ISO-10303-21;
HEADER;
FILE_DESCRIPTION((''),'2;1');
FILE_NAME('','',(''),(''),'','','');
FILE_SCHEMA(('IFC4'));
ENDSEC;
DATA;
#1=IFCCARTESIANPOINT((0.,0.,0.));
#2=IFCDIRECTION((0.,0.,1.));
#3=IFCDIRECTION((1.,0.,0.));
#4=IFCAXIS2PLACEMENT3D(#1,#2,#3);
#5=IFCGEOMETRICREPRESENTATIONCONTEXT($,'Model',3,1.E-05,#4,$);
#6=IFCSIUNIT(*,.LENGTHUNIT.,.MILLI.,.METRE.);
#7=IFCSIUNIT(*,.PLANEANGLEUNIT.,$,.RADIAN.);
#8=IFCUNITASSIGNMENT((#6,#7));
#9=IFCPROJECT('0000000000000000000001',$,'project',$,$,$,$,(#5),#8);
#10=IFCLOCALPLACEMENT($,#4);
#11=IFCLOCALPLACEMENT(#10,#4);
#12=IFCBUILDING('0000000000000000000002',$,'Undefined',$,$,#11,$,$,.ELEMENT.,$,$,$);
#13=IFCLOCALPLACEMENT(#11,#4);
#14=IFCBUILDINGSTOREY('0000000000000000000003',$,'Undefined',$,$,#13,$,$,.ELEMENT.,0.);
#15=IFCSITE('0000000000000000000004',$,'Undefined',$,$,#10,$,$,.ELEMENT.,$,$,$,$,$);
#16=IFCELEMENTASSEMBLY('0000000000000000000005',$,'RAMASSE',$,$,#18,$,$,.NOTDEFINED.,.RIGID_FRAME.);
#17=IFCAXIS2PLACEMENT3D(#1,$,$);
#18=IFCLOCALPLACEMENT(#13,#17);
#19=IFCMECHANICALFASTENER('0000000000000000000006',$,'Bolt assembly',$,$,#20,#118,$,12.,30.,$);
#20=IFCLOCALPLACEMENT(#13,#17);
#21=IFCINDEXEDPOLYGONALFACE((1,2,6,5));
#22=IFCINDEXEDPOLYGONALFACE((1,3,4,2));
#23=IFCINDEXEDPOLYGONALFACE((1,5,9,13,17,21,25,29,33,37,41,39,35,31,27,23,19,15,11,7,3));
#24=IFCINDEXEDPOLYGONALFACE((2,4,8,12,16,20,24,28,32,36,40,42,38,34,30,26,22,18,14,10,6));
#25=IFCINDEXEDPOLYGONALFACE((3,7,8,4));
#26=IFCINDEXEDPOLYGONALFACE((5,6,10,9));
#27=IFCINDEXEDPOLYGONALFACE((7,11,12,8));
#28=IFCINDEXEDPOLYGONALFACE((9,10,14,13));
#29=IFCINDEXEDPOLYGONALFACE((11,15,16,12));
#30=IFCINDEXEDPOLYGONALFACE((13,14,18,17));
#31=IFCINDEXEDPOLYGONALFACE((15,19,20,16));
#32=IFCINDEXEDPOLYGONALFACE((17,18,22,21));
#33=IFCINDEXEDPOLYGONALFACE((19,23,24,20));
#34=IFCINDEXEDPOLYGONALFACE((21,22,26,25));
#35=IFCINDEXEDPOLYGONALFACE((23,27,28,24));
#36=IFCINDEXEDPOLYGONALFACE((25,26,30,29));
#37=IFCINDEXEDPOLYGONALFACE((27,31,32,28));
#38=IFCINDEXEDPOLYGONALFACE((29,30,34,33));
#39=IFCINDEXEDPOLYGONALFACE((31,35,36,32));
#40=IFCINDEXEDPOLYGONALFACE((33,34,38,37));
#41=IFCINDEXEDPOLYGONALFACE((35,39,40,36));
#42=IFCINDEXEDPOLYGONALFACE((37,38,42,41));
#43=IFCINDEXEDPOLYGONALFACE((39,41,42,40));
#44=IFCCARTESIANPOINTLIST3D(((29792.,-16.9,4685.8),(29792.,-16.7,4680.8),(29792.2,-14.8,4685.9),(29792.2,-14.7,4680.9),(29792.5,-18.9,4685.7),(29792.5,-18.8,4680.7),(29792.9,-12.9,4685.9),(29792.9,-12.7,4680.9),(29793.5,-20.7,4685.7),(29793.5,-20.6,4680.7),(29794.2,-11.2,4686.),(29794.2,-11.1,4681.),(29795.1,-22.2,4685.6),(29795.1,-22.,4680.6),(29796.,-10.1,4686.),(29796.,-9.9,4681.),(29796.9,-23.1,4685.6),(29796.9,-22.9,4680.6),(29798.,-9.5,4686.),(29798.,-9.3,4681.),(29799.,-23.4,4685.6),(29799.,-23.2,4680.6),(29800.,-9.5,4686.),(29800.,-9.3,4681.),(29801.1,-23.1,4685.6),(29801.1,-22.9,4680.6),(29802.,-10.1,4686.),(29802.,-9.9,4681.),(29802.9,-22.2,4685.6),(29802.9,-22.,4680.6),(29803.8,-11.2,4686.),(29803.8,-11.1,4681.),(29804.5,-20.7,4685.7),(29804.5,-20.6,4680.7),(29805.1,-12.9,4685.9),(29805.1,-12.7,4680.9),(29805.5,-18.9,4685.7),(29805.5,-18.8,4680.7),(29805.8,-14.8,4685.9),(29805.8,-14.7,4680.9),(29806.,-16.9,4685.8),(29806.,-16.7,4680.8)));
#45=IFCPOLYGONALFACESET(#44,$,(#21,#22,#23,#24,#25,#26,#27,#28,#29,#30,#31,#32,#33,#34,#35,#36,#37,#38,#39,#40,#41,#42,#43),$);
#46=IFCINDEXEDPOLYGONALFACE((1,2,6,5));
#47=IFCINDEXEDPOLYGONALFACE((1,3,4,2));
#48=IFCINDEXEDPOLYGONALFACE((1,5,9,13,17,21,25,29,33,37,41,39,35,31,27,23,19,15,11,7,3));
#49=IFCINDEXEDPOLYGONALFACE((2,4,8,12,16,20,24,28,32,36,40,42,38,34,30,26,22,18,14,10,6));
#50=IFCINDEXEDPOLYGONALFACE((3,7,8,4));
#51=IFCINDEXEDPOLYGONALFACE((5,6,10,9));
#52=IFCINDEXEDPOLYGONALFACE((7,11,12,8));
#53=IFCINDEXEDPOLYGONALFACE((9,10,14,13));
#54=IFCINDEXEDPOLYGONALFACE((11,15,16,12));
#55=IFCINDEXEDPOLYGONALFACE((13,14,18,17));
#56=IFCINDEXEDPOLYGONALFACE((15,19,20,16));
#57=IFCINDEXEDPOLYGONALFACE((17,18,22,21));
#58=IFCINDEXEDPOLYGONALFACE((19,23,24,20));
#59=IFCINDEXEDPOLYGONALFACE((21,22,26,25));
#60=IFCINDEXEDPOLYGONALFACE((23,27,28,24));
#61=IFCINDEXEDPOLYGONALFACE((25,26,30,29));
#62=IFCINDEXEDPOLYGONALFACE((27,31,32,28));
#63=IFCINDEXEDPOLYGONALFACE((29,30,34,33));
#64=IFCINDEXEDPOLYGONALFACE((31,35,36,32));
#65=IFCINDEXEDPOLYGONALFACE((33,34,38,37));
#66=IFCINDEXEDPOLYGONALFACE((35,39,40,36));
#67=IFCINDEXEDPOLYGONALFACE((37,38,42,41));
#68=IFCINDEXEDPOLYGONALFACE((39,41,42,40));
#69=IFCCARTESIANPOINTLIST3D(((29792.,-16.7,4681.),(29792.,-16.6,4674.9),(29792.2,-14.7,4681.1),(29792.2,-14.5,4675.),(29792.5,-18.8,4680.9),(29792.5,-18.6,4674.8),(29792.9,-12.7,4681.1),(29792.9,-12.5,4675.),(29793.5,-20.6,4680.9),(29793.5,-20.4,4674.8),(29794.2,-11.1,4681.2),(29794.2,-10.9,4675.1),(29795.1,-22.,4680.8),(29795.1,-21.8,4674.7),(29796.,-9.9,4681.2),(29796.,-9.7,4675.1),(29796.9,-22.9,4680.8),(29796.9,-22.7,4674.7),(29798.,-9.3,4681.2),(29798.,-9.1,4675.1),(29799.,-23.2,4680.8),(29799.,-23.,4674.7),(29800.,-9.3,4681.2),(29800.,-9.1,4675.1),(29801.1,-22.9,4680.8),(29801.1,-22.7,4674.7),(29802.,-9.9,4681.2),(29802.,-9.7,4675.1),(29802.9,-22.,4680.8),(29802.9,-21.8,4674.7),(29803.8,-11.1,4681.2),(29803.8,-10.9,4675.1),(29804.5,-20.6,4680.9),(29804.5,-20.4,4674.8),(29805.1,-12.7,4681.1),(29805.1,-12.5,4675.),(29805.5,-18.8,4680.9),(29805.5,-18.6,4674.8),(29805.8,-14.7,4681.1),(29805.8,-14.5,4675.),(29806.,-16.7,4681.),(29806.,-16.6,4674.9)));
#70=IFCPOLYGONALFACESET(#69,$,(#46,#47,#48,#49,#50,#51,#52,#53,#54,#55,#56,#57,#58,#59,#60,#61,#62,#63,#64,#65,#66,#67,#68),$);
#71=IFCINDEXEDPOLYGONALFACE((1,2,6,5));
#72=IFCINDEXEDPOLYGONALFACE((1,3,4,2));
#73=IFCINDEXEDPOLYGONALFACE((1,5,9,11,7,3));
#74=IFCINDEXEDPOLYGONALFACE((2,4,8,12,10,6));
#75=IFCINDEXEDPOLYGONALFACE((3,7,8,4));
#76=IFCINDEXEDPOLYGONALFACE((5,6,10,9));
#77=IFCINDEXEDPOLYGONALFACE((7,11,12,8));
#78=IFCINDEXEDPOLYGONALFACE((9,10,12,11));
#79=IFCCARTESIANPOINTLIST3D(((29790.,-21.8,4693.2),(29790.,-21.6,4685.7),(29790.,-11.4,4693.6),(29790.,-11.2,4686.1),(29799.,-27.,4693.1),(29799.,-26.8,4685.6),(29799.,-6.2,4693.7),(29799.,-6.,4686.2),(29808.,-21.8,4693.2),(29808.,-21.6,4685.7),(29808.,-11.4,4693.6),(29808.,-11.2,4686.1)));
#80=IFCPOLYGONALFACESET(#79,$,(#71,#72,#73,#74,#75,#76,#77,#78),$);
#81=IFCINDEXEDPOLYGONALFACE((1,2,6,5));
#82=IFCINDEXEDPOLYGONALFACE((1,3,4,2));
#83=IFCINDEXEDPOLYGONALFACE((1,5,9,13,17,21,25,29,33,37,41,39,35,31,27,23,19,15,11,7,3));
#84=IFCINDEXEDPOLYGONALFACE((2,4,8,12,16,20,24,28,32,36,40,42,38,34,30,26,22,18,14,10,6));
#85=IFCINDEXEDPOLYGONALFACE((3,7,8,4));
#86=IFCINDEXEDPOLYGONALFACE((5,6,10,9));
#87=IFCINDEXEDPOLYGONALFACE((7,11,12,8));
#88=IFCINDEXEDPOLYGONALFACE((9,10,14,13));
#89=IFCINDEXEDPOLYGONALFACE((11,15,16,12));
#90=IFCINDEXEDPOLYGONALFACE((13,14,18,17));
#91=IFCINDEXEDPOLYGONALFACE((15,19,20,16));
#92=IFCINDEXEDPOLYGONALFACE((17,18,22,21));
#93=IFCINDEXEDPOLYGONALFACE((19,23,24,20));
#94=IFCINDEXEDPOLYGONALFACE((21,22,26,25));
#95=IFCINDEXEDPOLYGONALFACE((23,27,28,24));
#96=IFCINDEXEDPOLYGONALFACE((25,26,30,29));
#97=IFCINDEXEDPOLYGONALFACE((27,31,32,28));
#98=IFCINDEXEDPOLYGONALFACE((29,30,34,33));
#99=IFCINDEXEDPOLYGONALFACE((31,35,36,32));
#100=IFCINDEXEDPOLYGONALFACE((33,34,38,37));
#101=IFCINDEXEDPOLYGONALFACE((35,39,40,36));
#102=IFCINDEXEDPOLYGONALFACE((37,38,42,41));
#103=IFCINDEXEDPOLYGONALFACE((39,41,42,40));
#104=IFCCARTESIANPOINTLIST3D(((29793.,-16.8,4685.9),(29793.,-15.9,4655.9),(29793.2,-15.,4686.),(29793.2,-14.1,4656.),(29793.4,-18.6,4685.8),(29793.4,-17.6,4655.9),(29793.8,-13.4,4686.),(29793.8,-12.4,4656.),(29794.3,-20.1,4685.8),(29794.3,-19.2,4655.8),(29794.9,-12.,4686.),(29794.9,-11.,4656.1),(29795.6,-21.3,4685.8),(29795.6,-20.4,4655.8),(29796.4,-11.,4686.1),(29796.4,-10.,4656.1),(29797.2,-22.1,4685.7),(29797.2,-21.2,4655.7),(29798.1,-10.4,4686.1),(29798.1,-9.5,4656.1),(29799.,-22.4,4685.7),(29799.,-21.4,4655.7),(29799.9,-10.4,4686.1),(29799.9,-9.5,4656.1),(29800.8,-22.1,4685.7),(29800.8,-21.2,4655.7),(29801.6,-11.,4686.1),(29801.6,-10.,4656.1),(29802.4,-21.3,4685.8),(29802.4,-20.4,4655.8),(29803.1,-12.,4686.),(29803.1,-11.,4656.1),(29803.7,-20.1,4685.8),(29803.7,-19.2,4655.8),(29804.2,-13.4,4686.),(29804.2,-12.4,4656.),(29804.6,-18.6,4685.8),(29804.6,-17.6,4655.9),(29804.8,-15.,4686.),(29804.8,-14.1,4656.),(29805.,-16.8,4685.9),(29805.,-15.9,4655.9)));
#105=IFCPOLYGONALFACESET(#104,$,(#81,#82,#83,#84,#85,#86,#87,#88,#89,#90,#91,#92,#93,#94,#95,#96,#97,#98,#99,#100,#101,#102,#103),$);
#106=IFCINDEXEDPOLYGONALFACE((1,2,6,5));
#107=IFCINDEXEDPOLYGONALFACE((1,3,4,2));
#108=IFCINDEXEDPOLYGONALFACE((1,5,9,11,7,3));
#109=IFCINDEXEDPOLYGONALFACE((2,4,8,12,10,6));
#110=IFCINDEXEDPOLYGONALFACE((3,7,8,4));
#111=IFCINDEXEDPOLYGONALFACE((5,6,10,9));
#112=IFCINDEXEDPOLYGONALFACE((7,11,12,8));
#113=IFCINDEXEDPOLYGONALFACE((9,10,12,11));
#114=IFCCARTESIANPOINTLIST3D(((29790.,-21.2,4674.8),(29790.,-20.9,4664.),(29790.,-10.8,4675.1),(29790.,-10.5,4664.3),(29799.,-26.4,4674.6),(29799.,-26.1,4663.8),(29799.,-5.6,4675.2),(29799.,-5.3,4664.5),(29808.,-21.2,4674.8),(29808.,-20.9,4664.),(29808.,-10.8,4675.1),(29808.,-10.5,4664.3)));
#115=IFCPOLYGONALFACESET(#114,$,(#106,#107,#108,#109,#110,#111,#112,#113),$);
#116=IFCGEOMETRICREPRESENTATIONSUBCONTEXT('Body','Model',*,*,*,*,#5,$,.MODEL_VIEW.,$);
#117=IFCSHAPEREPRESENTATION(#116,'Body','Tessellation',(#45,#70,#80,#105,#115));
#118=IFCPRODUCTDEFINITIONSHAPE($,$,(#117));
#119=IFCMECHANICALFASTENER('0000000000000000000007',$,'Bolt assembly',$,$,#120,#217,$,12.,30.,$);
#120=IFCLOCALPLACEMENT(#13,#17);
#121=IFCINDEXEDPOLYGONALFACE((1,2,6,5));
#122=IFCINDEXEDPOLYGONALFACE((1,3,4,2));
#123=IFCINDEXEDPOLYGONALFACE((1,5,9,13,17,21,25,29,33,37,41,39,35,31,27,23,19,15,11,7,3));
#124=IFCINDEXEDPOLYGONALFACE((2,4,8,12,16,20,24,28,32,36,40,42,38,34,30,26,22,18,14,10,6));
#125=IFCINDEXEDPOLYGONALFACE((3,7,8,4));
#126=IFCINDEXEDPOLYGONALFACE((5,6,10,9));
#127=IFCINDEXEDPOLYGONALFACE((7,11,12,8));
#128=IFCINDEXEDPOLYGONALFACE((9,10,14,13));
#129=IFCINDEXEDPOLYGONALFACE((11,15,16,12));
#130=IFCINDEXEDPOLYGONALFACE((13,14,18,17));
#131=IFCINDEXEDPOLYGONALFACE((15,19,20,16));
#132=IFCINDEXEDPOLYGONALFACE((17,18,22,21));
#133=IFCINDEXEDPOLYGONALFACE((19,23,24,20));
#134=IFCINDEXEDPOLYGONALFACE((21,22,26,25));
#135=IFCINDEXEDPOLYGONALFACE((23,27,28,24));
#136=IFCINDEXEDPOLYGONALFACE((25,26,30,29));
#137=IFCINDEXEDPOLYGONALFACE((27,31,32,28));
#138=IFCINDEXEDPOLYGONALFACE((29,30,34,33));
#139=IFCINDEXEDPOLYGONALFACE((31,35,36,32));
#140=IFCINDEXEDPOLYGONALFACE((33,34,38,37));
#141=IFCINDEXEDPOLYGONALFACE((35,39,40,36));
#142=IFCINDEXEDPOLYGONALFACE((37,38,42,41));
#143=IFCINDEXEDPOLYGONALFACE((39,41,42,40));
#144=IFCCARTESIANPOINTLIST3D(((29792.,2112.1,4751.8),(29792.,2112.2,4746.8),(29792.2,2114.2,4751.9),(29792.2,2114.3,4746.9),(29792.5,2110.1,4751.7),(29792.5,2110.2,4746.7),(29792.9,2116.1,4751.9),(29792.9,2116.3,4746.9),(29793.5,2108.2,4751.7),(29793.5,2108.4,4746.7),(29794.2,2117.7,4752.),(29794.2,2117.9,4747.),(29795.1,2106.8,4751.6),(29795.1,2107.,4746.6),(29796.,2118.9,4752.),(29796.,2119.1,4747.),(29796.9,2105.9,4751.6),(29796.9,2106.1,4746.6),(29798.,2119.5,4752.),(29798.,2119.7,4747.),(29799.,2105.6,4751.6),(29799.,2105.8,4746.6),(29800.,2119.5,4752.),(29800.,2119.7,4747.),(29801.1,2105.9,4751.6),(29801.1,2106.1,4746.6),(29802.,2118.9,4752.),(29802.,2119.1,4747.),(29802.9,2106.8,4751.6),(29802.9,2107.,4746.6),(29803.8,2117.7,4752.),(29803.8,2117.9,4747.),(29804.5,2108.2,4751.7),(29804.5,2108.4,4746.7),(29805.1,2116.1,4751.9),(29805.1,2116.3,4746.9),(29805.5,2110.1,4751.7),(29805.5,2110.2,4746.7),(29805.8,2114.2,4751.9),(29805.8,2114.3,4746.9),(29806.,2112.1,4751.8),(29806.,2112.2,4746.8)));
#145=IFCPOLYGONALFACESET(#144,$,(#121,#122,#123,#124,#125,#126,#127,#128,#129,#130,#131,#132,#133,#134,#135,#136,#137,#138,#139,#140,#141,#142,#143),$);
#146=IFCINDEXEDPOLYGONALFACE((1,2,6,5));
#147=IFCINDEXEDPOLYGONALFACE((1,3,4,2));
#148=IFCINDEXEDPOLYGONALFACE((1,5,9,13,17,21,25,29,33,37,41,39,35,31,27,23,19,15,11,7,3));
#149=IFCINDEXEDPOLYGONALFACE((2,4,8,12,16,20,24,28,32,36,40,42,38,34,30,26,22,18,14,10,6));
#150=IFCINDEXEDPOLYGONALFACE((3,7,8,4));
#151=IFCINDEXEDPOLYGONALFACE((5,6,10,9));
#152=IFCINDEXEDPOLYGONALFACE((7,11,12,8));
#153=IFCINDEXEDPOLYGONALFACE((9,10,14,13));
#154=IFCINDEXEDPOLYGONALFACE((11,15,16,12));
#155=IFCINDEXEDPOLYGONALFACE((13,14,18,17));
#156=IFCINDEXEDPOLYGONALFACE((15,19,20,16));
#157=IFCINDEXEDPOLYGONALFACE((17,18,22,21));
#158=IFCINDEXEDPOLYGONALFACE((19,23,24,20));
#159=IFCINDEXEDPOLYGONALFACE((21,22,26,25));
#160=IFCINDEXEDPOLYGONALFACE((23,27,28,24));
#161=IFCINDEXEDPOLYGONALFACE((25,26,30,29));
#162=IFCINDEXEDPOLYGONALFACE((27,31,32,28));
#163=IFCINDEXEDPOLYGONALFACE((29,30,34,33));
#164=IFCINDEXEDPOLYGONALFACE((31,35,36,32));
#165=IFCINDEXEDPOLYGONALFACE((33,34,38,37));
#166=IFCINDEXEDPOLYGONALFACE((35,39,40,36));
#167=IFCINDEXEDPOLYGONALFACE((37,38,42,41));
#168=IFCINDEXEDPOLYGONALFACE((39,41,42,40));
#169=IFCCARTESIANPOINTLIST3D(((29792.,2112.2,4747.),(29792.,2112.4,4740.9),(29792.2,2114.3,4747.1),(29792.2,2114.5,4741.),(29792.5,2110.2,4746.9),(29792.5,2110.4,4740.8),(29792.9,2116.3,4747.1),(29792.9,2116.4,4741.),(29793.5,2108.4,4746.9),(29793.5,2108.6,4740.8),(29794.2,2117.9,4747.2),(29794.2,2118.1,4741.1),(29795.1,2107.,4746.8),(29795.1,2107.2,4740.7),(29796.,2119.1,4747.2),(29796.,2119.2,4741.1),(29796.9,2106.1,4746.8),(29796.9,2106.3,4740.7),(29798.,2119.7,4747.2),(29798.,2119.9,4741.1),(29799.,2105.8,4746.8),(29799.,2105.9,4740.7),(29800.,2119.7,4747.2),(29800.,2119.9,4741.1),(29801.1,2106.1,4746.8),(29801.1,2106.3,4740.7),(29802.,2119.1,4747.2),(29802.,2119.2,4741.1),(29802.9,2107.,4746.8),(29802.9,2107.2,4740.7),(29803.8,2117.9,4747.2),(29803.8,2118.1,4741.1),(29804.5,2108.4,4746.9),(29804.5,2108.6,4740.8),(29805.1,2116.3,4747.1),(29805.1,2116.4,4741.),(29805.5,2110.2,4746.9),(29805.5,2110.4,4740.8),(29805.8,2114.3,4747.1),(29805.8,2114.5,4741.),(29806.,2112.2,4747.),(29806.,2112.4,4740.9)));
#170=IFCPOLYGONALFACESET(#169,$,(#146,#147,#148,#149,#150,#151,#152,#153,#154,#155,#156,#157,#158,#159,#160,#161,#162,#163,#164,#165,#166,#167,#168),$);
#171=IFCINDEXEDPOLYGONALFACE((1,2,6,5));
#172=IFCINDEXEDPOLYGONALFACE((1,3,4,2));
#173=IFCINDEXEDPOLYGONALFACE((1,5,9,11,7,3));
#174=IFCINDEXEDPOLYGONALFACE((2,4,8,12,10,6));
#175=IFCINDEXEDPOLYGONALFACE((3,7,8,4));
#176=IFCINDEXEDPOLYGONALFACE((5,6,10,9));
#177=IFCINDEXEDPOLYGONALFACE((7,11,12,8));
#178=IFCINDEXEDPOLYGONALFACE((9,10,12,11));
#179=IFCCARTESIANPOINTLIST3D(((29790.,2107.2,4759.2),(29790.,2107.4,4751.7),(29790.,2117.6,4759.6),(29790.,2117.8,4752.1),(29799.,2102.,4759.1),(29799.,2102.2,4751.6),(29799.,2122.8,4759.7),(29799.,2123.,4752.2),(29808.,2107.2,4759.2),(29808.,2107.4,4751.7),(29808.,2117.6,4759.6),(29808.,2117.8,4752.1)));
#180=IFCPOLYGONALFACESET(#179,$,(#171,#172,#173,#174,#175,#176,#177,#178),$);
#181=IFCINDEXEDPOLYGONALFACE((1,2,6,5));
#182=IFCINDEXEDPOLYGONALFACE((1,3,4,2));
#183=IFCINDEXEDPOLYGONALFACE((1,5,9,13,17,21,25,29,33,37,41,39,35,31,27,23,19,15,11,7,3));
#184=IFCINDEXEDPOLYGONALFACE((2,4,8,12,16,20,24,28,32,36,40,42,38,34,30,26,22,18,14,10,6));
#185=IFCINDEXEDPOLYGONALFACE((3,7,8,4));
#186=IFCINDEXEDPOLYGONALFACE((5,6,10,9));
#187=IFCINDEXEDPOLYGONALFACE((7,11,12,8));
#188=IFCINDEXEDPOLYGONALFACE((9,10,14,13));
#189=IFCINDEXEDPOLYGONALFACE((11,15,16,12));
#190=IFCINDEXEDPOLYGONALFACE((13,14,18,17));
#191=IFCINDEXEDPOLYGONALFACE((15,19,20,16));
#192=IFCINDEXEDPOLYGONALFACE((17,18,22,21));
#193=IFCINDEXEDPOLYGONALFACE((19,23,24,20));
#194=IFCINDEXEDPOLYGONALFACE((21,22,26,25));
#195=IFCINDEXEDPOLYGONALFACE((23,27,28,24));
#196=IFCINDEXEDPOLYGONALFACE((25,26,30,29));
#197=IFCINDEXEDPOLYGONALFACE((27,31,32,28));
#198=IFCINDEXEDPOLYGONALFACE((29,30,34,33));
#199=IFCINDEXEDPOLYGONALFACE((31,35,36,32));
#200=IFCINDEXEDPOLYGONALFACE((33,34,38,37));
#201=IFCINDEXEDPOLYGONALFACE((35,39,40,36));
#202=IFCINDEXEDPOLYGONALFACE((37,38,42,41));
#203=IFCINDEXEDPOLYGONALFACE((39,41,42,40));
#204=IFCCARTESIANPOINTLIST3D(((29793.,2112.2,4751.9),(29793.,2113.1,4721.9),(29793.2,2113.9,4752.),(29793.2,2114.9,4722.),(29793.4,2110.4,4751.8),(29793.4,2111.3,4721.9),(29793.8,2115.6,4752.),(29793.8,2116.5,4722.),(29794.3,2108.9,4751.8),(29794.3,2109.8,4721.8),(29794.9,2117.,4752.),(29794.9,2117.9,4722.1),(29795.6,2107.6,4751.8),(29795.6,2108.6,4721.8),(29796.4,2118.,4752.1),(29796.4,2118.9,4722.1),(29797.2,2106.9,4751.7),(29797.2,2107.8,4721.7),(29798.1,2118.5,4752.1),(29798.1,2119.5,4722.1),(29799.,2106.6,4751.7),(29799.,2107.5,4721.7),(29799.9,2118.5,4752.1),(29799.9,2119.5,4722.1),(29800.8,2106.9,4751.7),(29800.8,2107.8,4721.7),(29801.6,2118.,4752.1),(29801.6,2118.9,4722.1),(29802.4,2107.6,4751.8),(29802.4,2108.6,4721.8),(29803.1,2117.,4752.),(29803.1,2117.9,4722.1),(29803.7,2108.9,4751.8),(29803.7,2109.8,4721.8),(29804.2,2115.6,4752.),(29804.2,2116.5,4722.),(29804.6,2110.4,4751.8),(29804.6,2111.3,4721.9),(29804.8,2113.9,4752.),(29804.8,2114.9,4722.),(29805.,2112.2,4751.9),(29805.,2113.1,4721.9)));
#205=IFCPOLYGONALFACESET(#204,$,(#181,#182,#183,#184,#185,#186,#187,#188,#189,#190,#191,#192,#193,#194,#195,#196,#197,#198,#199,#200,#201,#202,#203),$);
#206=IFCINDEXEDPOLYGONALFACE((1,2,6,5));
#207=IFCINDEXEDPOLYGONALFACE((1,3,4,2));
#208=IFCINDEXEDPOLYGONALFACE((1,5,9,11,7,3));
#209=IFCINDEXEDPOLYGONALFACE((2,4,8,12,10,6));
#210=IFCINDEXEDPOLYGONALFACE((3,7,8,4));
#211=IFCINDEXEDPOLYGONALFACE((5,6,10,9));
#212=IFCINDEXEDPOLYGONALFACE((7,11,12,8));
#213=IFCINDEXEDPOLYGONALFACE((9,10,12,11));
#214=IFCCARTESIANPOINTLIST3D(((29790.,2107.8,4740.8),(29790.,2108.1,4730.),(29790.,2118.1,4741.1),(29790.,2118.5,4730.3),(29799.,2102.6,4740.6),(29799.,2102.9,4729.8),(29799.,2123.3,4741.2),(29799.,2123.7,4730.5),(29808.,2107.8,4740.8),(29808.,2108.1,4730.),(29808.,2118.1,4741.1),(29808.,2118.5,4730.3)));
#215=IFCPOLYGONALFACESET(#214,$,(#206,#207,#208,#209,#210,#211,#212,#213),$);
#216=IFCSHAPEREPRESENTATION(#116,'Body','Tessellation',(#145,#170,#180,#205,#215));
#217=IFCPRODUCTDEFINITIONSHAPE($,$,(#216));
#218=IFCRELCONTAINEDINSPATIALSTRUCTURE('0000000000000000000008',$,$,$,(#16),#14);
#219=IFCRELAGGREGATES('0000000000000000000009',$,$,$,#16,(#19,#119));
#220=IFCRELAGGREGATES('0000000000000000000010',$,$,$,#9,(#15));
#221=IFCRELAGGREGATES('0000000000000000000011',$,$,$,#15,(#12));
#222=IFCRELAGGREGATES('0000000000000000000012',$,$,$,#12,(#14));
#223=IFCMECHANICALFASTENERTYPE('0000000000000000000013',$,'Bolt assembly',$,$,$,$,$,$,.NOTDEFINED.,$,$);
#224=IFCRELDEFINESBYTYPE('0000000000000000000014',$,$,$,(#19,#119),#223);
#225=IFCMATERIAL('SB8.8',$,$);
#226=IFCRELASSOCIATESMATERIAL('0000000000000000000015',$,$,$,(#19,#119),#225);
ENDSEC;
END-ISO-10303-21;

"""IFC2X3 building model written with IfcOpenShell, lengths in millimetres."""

from ifc_helpers import new_model, si_unit, frame, origin_with_axes, origin_2d_with_axis, place, context, subcontext, project, spatial, polyline, circle, outline, extrude, source, transform, mapped, material, type_object, element, aggregate, save


model = new_model("IFC2X3")

# Units and contexts
model_context = context("Model", 3, precision=1e-05, world=origin_with_axes())
body_context = subcontext(model_context, "Body", "Model", "MODEL_VIEW")
ifc_project = project(units=[si_unit("LENGTHUNIT", "METRE", prefix="MILLI"), si_unit("PLANEANGLEUNIT", "RADIAN")], contexts=[model_context])

# Site, building, storey
site_placement = place(None, origin_with_axes())
site = spatial("IfcSite", under=ifc_project, at=site_placement, Name="Undefined", CompositionType="ELEMENT")
building_placement = place(site_placement, origin_with_axes())
building = spatial("IfcBuilding", under=site, at=building_placement, Name="Undefined", CompositionType="ELEMENT")
storey_placement = place(building_placement, origin_with_axes())
storey = spatial("IfcBuildingStorey", under=building, at=storey_placement, Name="Undefined", CompositionType="ELEMENT", Elevation=0.0)

# Element assembly
assembly_1_placement = place(storey_placement, origin_with_axes())
assembly_1 = element("IfcElementAssembly", 1, at=assembly_1_placement, inside=storey, Name="RAMASSE", AssemblyPlace="NOTDEFINED", PredefinedType="RIGID_FRAME")

# Shared definitions
ifc_material_1 = material(Name="SB8.8")
mechanical_fastener_type = type_object("IfcMechanicalFastenerType", Name="Bolt assembly")

# Mechanical fasteners
shared_shape_1 = source(origin_with_axes(), body_context, "Body", "SweptSolid", [
    extrude(circle(Radius=7.0, at=origin_2d_with_axis()), frame((0.0, -4.9, 0.0), z_axis=(0.0, 1.0, 0.0), x_axis=(1.0, 0.0, 0.0)), (0.0, 0.0, 1.0), 5.0),
    extrude(circle(Radius=7.0, at=origin_2d_with_axis()), frame((0.0, -0.1, 0.0), z_axis=(0.0, 1.0, 0.0), x_axis=(1.0, 0.0, 0.0)), (0.0, 0.0, 1.0), 6.1),
    extrude(outline(polyline([(10.4, 0.0), (5.2, 9.0), (-5.2, 9.0), (-10.4, 0.0), (-5.2, -9.0), (5.2, -9.0), (10.4, 0.0)])), frame((0.0, -12.5, 0.0), z_axis=(0.0, 1.0, 0.0), x_axis=(1.0, 0.0, 0.0)), (0.0, 0.0, 1.0), 7.5),
    extrude(circle(Radius=6.0, at=origin_2d_with_axis()), frame((0.0, -5.0, 0.0), z_axis=(0.0, 1.0, 0.0), x_axis=(1.0, 0.0, 0.0)), (0.0, 0.0, 1.0), 30.0),
    extrude(outline(polyline([(10.4, 0.0), (5.2, 9.0), (-5.2, 9.0), (-10.4, 0.0), (-5.2, -9.0), (5.2, -9.0), (10.4, 0.0)])), frame((0.0, 6.0, 0.0), z_axis=(0.0, 1.0, 0.0), x_axis=(1.0, 0.0, 0.0)), (0.0, 0.0, 1.0), 10.8),
])
mechanical_fastener_1_placement = place(assembly_1_placement, frame((29799.0, -16.2, 4680.9), z_axis=(1.0, 0.0, 0.0), x_axis=(0.0, -0.99952, -0.030986)))
mechanical_fastener_1 = element("IfcMechanicalFastener", 2, at=mechanical_fastener_1_placement, type_object=mechanical_fastener_type, material=ifc_material_1, Name="Bolt assembly", NominalDiameter=12.0, NominalLength=30.0, context=body_context, shape_type="MappedRepresentation", body=[
    mapped(shared_shape_1, transform((0.0, 0.0, 0.0))),
])
mechanical_fastener_2_placement = place(assembly_1_placement, frame((29799.0, 2112.8, 4746.9), z_axis=(1.0, 0.0, 0.0), x_axis=(0.0, -0.99952, -0.030986)))
mechanical_fastener_2 = element("IfcMechanicalFastener", 3, at=mechanical_fastener_2_placement, type_object=mechanical_fastener_type, material=ifc_material_1, Name="Bolt assembly", NominalDiameter=12.0, NominalLength=30.0, context=body_context, shape_type="MappedRepresentation", body=[
    mapped(shared_shape_1, transform((0.0, 0.0, 0.0))),
])
aggregate(assembly_1, [mechanical_fastener_1, mechanical_fastener_2])

save(model, "model.ifc")
